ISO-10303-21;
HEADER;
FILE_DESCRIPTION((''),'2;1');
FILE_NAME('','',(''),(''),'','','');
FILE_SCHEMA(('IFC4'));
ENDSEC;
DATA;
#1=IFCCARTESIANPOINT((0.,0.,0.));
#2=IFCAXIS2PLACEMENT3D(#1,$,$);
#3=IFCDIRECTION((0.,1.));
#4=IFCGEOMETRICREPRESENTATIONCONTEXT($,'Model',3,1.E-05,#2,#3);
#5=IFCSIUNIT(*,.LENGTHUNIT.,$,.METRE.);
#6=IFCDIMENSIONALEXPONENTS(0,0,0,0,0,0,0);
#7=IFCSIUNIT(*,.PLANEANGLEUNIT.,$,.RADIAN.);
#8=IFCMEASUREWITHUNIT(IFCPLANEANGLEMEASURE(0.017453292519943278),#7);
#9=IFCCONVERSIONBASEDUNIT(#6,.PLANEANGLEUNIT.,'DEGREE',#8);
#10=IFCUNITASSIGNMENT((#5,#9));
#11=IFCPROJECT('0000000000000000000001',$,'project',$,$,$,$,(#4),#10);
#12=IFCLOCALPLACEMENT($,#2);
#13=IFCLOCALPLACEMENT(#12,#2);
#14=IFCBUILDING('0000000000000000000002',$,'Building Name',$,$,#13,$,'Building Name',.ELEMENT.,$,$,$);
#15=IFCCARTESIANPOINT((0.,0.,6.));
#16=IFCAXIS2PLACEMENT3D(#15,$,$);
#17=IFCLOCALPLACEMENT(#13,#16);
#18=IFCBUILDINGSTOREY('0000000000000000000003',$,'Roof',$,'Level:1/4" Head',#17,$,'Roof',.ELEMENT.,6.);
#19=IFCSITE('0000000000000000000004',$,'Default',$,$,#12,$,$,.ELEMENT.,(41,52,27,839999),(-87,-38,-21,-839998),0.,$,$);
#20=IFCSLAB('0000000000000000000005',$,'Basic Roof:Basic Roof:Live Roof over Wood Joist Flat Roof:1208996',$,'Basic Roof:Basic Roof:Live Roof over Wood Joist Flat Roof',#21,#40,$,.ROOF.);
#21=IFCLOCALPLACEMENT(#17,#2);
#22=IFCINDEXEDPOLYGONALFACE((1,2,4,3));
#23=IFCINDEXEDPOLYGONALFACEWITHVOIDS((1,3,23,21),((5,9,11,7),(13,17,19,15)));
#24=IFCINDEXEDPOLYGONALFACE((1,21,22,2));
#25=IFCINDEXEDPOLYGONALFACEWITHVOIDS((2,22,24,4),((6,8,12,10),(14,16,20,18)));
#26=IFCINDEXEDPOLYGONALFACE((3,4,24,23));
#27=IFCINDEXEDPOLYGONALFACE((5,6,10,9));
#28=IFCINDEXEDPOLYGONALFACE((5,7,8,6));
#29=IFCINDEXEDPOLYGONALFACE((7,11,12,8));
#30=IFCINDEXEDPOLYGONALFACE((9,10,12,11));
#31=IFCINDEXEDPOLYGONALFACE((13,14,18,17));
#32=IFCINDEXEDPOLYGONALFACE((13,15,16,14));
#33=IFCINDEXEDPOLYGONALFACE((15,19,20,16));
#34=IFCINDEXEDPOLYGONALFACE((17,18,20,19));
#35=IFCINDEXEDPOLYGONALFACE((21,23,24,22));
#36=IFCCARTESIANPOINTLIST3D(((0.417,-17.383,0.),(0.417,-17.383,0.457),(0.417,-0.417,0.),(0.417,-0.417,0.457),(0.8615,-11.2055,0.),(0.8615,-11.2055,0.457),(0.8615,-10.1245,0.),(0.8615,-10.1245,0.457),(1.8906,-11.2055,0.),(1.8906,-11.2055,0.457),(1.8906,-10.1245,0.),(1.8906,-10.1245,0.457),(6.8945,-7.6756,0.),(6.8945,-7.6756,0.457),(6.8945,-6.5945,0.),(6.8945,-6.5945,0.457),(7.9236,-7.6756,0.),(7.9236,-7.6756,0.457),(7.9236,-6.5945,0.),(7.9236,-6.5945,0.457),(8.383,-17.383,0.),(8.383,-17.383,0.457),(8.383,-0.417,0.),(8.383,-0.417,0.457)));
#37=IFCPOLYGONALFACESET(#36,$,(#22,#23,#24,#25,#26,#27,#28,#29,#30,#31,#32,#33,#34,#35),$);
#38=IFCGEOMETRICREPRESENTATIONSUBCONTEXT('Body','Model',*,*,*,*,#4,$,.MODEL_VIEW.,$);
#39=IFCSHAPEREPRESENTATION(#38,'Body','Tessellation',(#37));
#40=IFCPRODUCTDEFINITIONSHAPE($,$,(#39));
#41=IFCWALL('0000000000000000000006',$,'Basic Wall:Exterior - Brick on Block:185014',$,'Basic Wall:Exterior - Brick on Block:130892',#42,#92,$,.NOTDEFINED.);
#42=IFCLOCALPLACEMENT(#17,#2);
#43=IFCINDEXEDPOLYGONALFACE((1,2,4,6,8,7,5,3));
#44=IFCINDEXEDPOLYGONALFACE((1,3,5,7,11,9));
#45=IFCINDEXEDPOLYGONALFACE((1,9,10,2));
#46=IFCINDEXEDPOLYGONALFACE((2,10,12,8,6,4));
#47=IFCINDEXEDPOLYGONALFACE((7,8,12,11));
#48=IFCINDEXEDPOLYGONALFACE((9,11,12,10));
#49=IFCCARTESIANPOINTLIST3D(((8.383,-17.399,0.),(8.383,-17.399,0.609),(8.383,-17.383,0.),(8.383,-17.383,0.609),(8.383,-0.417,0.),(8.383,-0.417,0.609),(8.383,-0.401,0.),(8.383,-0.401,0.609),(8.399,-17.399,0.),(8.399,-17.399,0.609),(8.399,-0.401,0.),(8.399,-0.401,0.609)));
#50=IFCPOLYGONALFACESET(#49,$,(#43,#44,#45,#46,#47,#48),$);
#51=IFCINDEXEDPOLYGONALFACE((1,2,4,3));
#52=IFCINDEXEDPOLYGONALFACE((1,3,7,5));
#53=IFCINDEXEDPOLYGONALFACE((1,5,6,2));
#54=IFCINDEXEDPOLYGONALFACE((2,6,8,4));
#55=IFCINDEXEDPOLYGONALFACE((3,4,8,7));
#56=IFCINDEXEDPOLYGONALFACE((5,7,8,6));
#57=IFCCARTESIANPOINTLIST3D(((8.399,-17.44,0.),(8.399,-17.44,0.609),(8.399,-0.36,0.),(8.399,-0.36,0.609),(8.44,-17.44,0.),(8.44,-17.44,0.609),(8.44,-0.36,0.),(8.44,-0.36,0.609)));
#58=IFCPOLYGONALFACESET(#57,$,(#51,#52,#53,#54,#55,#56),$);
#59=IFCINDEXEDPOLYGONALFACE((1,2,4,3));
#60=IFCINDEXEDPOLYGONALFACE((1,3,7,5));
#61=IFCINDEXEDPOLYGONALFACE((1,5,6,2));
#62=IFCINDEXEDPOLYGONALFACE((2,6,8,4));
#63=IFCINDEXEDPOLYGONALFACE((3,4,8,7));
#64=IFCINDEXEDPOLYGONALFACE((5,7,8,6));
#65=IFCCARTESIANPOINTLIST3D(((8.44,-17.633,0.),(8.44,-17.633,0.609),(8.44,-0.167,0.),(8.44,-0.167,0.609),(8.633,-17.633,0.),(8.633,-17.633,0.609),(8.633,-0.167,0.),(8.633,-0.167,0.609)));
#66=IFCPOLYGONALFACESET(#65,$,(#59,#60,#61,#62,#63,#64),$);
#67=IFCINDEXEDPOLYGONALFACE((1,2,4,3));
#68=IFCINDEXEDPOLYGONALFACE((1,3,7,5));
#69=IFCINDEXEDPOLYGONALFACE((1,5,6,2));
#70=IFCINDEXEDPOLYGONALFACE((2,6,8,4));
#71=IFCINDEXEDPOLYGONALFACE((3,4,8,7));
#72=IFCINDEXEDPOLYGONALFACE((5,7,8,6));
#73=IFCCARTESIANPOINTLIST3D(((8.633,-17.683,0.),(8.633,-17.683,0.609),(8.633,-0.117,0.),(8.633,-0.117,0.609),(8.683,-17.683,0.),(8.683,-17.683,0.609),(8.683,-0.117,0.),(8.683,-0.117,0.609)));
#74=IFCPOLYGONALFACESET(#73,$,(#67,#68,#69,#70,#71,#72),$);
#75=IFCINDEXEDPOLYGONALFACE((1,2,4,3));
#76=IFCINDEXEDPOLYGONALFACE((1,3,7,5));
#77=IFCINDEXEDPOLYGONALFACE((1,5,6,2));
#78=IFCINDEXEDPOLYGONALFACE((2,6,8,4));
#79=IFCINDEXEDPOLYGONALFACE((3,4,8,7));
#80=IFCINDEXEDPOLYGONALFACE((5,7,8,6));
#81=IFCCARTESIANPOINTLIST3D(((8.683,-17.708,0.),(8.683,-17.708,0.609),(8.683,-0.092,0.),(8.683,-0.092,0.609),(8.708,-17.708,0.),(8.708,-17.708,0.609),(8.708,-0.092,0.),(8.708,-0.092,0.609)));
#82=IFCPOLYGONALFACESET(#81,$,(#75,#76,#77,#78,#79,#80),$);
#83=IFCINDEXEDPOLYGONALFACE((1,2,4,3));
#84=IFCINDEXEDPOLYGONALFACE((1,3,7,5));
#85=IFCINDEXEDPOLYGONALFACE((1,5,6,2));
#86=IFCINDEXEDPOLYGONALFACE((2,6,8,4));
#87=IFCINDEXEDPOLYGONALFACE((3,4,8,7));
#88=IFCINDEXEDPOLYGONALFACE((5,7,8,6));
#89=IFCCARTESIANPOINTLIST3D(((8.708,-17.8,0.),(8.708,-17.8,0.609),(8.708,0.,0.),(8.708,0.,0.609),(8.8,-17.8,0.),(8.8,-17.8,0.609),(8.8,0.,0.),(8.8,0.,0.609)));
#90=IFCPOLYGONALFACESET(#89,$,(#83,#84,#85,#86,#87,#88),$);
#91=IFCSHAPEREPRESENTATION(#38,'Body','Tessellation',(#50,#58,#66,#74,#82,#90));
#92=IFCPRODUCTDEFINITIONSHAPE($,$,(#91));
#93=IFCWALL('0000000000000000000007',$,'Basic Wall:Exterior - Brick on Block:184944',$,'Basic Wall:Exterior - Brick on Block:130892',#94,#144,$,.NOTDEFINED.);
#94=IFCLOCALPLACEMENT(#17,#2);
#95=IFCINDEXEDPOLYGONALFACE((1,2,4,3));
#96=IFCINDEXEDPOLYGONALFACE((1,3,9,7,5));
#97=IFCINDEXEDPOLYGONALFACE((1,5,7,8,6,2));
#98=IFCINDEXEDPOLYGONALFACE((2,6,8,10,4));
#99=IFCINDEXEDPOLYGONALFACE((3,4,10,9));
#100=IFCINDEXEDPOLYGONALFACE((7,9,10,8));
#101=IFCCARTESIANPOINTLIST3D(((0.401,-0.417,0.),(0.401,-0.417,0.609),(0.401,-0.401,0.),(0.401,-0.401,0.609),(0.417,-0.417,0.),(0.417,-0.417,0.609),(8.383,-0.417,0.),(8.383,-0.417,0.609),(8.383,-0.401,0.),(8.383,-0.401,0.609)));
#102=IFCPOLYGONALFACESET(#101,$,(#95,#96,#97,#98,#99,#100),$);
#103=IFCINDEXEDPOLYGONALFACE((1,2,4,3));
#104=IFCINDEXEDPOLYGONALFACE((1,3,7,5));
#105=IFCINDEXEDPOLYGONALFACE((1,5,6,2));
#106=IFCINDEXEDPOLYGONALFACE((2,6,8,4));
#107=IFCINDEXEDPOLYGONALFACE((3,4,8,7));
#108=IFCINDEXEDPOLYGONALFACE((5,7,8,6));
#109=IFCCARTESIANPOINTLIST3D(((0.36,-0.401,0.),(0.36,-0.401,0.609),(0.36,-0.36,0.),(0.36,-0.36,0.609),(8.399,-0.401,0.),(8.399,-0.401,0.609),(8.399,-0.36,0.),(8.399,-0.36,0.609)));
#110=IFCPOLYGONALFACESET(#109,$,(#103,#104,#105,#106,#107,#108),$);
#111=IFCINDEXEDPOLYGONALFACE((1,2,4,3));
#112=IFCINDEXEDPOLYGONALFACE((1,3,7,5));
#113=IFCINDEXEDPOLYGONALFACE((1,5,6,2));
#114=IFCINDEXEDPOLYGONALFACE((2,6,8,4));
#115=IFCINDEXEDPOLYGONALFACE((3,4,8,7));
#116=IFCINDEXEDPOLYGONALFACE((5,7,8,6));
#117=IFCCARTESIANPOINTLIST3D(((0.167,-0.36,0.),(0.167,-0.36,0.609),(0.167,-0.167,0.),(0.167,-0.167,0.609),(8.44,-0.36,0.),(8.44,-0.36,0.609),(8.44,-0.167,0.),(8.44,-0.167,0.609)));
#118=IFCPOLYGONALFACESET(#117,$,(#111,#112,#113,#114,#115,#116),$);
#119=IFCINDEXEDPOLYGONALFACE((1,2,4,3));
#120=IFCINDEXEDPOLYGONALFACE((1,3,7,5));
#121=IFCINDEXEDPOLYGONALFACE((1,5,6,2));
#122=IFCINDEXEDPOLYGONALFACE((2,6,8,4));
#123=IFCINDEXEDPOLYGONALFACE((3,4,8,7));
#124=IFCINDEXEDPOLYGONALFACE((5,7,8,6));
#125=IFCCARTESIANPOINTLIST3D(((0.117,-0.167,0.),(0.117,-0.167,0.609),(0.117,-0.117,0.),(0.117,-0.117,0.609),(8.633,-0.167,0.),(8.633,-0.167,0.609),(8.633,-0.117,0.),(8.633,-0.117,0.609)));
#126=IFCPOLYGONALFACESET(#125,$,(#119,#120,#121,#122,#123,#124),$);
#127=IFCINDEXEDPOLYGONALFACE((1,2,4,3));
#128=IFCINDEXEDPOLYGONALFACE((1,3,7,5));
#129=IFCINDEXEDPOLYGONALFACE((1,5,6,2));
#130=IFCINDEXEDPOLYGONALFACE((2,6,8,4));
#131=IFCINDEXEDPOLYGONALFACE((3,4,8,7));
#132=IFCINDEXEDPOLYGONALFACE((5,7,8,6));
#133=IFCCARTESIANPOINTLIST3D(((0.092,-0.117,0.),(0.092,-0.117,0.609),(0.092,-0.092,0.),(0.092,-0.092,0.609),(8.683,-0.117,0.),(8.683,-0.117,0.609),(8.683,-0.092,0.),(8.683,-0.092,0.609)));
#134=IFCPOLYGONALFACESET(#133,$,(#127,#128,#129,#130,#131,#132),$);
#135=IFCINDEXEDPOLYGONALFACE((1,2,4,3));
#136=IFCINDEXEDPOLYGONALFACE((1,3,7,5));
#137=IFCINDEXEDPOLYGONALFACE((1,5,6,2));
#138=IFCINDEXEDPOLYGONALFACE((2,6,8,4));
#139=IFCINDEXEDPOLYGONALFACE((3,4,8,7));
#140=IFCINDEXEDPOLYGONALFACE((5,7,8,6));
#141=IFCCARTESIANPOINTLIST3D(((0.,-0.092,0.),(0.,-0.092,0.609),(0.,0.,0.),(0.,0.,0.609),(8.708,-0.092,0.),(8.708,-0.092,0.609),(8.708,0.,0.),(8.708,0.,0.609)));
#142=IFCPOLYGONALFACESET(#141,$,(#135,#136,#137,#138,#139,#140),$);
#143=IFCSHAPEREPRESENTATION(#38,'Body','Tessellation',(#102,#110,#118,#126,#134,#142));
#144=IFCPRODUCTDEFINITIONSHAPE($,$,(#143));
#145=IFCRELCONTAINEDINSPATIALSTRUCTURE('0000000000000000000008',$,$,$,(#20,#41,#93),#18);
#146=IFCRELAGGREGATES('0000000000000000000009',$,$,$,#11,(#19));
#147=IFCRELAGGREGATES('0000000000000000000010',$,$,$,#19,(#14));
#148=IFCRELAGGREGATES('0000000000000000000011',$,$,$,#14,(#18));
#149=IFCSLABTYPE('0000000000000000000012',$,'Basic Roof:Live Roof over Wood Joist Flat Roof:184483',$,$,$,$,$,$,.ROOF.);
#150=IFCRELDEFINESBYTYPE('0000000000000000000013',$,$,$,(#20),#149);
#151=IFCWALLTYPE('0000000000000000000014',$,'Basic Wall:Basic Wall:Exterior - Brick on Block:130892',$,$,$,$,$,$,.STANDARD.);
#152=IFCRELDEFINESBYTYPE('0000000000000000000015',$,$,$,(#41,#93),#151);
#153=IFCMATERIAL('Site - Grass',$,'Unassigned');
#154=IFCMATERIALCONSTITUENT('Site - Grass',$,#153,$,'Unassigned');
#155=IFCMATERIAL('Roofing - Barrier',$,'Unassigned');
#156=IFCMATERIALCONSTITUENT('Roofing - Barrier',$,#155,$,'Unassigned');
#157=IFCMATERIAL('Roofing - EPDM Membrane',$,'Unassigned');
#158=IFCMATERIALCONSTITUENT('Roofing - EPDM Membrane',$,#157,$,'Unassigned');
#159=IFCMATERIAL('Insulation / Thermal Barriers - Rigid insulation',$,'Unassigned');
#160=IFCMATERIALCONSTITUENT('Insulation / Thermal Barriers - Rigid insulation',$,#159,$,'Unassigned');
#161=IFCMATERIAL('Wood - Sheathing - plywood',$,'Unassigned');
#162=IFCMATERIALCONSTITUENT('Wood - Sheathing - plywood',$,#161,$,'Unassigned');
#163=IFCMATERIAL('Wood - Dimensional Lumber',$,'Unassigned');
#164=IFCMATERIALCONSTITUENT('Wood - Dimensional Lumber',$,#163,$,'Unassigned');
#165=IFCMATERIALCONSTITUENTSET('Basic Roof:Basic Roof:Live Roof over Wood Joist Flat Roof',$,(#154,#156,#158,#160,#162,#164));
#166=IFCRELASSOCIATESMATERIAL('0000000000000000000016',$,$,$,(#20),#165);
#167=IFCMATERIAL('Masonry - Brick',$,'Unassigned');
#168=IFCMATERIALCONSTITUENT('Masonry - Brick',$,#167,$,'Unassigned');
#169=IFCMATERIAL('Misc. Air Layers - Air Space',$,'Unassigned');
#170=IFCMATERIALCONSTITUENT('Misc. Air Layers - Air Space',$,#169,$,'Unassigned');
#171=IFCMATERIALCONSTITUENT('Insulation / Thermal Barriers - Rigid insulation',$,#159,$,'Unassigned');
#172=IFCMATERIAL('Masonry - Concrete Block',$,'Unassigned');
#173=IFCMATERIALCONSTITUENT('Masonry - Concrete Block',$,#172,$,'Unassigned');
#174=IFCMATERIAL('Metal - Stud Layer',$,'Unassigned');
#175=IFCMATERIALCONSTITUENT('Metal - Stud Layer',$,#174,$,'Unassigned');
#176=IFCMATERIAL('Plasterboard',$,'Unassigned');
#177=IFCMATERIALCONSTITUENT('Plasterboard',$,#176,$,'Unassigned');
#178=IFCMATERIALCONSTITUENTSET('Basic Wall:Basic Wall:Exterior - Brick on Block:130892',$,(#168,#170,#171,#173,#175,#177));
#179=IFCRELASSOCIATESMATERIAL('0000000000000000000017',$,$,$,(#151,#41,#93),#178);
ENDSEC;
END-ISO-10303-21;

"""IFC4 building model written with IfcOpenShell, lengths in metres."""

from ifc_helpers import new_model, entity, si_unit, converted_unit, direction, frame, origin, place, context, subcontext, project, spatial, indexed_curve, outline, extrude, material, constituent, constituent_set, type_object, element, save


model = new_model("IFC4")

# Units and contexts
model_context = context("Model", 3, precision=1e-05, world=origin(), true_north=direction((0.0, 1.0)))
body_context = subcontext(model_context, "Body", "Model", "MODEL_VIEW")
ifc_project = project(units=[si_unit("LENGTHUNIT", "METRE"), converted_unit("PLANEANGLEUNIT", "DEGREE", entity("IfcPlaneAngleMeasure", 0.017453292519943278), si_unit("PLANEANGLEUNIT", "RADIAN"), dimensions=[0, 0, 0, 0, 0, 0, 0])], contexts=[model_context])

# Site, building, storey
site_placement = place(None, origin())
site = spatial("IfcSite", under=ifc_project, at=site_placement, Name="Default", CompositionType="ELEMENT", RefLatitude=(41, 52, 27, 839999), RefLongitude=(-87, -38, -21, -839998), RefElevation=0.0)
building_placement = place(site_placement, origin())
building = spatial("IfcBuilding", under=site, at=building_placement, Name="Building Name", LongName="Building Name", CompositionType="ELEMENT")
storey_placement = place(building_placement, frame((0.0, 0.0, 6.0)))
storey = spatial("IfcBuildingStorey", under=building, at=storey_placement, Name="Roof", ObjectType="Level:1/4\" Head", LongName="Roof", CompositionType="ELEMENT", Elevation=6.0)

# Slab, openings
ifc_material_1 = material(Name="Site - Grass", Category="Unassigned")
ifc_constituent_1 = constituent(ifc_material_1, Name="Site - Grass", Category="Unassigned")
ifc_material_2 = material(Name="Roofing - Barrier", Category="Unassigned")
ifc_constituent_2 = constituent(ifc_material_2, Name="Roofing - Barrier", Category="Unassigned")
ifc_material_3 = material(Name="Roofing - EPDM Membrane", Category="Unassigned")
ifc_constituent_3 = constituent(ifc_material_3, Name="Roofing - EPDM Membrane", Category="Unassigned")
ifc_material_4 = material(Name="Insulation / Thermal Barriers - Rigid insulation", Category="Unassigned")
ifc_constituent_4 = constituent(ifc_material_4, Name="Insulation / Thermal Barriers - Rigid insulation", Category="Unassigned")
ifc_material_5 = material(Name="Wood - Sheathing - plywood", Category="Unassigned")
ifc_constituent_5 = constituent(ifc_material_5, Name="Wood - Sheathing - plywood", Category="Unassigned")
ifc_material_6 = material(Name="Wood - Dimensional Lumber", Category="Unassigned")
ifc_constituent_6 = constituent(ifc_material_6, Name="Wood - Dimensional Lumber", Category="Unassigned")
ifc_constituent_set_1 = constituent_set(constituents=[ifc_constituent_1, ifc_constituent_2, ifc_constituent_3, ifc_constituent_4, ifc_constituent_5, ifc_constituent_6], Name="Basic Roof:Basic Roof:Live Roof over Wood Joist Flat Roof")
slab_type = type_object("IfcSlabType", Name="Basic Roof:Live Roof over Wood Joist Flat Roof:184483", PredefinedType="ROOF")
slab_placement = place(storey_placement, origin())
slab = element("IfcSlab", 1, at=slab_placement, inside=storey, type_object=slab_type, material=ifc_constituent_set_1, Name="Basic Roof:Basic Roof:Live Roof over Wood Joist Flat Roof:1208996", ObjectType="Basic Roof:Basic Roof:Live Roof over Wood Joist Flat Roof", PredefinedType="ROOF", context=body_context, shape_type="SweptSolid", body=[
    extrude(outline(indexed_curve([(-8.483, -3.983), (8.483, -3.983), (8.483, 3.983), (-8.483, 3.983), (-8.483, -3.983)], self_intersect=False)), frame((4.4, -8.9, 0.0), z_axis=(0.0, 0.0, 1.0), x_axis=(0.0, 1.0, 0.0)), (0.0, 0.0, 1.0), 0.457),
])
opening_1_placement = place(storey_placement, origin())
element("IfcOpeningElement", 2, at=opening_1_placement, cuts=slab, PredefinedType="OPENING", context=body_context, shape_type="SweptSolid", body=[
    extrude(outline(indexed_curve([(-0.5146, -0.5405), (0.5145, -0.5405), (0.5145, 0.5405), (-0.5146, 0.5405), (-0.5146, -0.5405)], self_intersect=False)), frame((1.376, -10.665, 0.0)), (0.0, 0.0, 1.0), 0.457),
])
opening_2_placement = place(storey_placement, origin())
element("IfcOpeningElement", 3, at=opening_2_placement, cuts=slab, PredefinedType="OPENING", context=body_context, shape_type="SweptSolid", body=[
    extrude(outline(indexed_curve([(-0.5145, -0.5405), (0.5145, -0.5405), (0.5145, 0.5405), (-0.5145, 0.5405), (-0.5145, -0.5405)], self_intersect=False)), frame((7.409, -7.135, 0.0)), (0.0, 0.0, 1.0), 0.457),
])

# Walls
ifc_material_7 = material(Name="Masonry - Brick", Category="Unassigned")
ifc_constituent_7 = constituent(ifc_material_7, Name="Masonry - Brick", Category="Unassigned")
ifc_material_8 = material(Name="Misc. Air Layers - Air Space", Category="Unassigned")
ifc_constituent_8 = constituent(ifc_material_8, Name="Misc. Air Layers - Air Space", Category="Unassigned")
ifc_constituent_9 = constituent(ifc_material_4, Name="Insulation / Thermal Barriers - Rigid insulation", Category="Unassigned")
ifc_material_9 = material(Name="Masonry - Concrete Block", Category="Unassigned")
ifc_constituent_10 = constituent(ifc_material_9, Name="Masonry - Concrete Block", Category="Unassigned")
ifc_material_10 = material(Name="Metal - Stud Layer", Category="Unassigned")
ifc_constituent_11 = constituent(ifc_material_10, Name="Metal - Stud Layer", Category="Unassigned")
ifc_material_11 = material(Name="Plasterboard", Category="Unassigned")
ifc_constituent_12 = constituent(ifc_material_11, Name="Plasterboard", Category="Unassigned")
ifc_constituent_set_2 = constituent_set(constituents=[ifc_constituent_7, ifc_constituent_8, ifc_constituent_9, ifc_constituent_10, ifc_constituent_11, ifc_constituent_12], Name="Basic Wall:Basic Wall:Exterior - Brick on Block:130892")
wall_type = type_object("IfcWallType", Name="Basic Wall:Basic Wall:Exterior - Brick on Block:130892", PredefinedType="STANDARD", material=ifc_constituent_set_2)
wall_1_placement = place(storey_placement, frame((8.5915, 0.0, 0.0), z_axis=(0.0, 0.0, 1.0), x_axis=(0.0, -1.0, 0.0)))
element("IfcWall", 4, at=wall_1_placement, inside=storey, type_object=wall_type, material=ifc_constituent_set_2, Name="Basic Wall:Exterior - Brick on Block:185014", ObjectType="Basic Wall:Exterior - Brick on Block:130892", PredefinedType="NOTDEFINED", context=body_context, shape_type="SweptSolid", body=[
    extrude(outline(indexed_curve([(-8.483, -0.0053), (8.483, -0.0053), (8.499, -0.0053), (8.499, 0.0107), (-8.499, 0.0107), (-8.499, -0.0053), (-8.483, -0.0053)], self_intersect=False)), frame((8.9, -0.2032, 0.0)), (0.0, 0.0, 1.0), 0.609),
    extrude(outline(indexed_curve([(-8.54, -0.0205), (8.54, -0.0205), (8.54, 0.0205), (-8.54, 0.0205), (-8.54, -0.0205)], self_intersect=False)), frame((8.9, -0.172, 0.0)), (0.0, 0.0, 1.0), 0.609),
    extrude(outline(indexed_curve([(-8.733, -0.0965), (8.733, -0.0965), (8.733, 0.0965), (-8.733, 0.0965), (-8.733, -0.0965)], self_intersect=False)), frame((8.9, -0.055, 0.0)), (0.0, 0.0, 1.0), 0.609),
    extrude(outline(indexed_curve([(-8.783, -0.025), (8.783, -0.025), (8.783, 0.025), (-8.783, 0.025), (-8.783, -0.025)], self_intersect=False)), frame((8.9, 0.0665, 0.0)), (0.0, 0.0, 1.0), 0.609),
    extrude(outline(indexed_curve([(-8.808, -0.0125), (8.808, -0.0125), (8.808, 0.0125), (-8.808, 0.0125), (-8.808, -0.0125)], self_intersect=False)), frame((8.9, 0.104, 0.0)), (0.0, 0.0, 1.0), 0.609),
    extrude(outline(indexed_curve([(-0.046, -8.9), (0.046, -8.9), (0.046, 8.9), (-0.046, 8.9), (-0.046, -8.9)], self_intersect=False)), frame((8.9, 0.1625, 0.0), z_axis=(0.0, 0.0, 1.0), x_axis=(0.0, -1.0, 0.0)), (0.0, 0.0, 1.0), 0.609),
])
wall_2_placement = place(storey_placement, frame((0.0, -0.2085, 0.0)))
element("IfcWall", 5, at=wall_2_placement, inside=storey, type_object=wall_type, material=ifc_constituent_set_2, Name="Basic Wall:Exterior - Brick on Block:184944", ObjectType="Basic Wall:Exterior - Brick on Block:130892", PredefinedType="NOTDEFINED", context=body_context, shape_type="SweptSolid", body=[
    extrude(outline(indexed_curve([(-3.18, -0.0064), (4.786, -0.0064), (4.786, 0.0096), (-3.196, 0.0096), (-3.196, -0.0064), (-3.18, -0.0064)], self_intersect=False)), frame((3.597, -0.2021, 0.0)), (0.0, 0.0, 1.0), 0.609),
    extrude(outline(indexed_curve([(-4.0195, -0.0205), (4.0195, -0.0205), (4.0195, 0.0205), (-4.0195, 0.0205), (-4.0195, -0.0205)], self_intersect=False)), frame((4.3795, -0.172, 0.0)), (0.0, 0.0, 1.0), 0.609),
    extrude(outline(indexed_curve([(-4.1365, -0.0965), (4.1365, -0.0965), (4.1365, 0.0965), (-4.1365, 0.0965), (-4.1365, -0.0965)], self_intersect=False)), frame((4.3035, -0.055, 0.0)), (0.0, 0.0, 1.0), 0.609),
    extrude(outline(indexed_curve([(-4.258, -0.025), (4.258, -0.025), (4.258, 0.025), (-4.258, 0.025), (-4.258, -0.025)], self_intersect=False)), frame((4.375, 0.0665, 0.0)), (0.0, 0.0, 1.0), 0.609),
    extrude(outline(indexed_curve([(-4.2955, -0.0125), (4.2955, -0.0125), (4.2955, 0.0125), (-4.2955, 0.0125), (-4.2955, -0.0125)], self_intersect=False)), frame((4.3875, 0.104, 0.0)), (0.0, 0.0, 1.0), 0.609),
    extrude(outline(indexed_curve([(-0.046, -4.354), (0.046, -4.354), (0.046, 4.354), (-0.046, 4.354), (-0.046, -4.354)], self_intersect=False)), frame((4.354, 0.1625, 0.0), z_axis=(0.0, 0.0, 1.0), x_axis=(0.0, -1.0, 0.0)), (0.0, 0.0, 1.0), 0.609),
])

save(model, "model.ifc")
